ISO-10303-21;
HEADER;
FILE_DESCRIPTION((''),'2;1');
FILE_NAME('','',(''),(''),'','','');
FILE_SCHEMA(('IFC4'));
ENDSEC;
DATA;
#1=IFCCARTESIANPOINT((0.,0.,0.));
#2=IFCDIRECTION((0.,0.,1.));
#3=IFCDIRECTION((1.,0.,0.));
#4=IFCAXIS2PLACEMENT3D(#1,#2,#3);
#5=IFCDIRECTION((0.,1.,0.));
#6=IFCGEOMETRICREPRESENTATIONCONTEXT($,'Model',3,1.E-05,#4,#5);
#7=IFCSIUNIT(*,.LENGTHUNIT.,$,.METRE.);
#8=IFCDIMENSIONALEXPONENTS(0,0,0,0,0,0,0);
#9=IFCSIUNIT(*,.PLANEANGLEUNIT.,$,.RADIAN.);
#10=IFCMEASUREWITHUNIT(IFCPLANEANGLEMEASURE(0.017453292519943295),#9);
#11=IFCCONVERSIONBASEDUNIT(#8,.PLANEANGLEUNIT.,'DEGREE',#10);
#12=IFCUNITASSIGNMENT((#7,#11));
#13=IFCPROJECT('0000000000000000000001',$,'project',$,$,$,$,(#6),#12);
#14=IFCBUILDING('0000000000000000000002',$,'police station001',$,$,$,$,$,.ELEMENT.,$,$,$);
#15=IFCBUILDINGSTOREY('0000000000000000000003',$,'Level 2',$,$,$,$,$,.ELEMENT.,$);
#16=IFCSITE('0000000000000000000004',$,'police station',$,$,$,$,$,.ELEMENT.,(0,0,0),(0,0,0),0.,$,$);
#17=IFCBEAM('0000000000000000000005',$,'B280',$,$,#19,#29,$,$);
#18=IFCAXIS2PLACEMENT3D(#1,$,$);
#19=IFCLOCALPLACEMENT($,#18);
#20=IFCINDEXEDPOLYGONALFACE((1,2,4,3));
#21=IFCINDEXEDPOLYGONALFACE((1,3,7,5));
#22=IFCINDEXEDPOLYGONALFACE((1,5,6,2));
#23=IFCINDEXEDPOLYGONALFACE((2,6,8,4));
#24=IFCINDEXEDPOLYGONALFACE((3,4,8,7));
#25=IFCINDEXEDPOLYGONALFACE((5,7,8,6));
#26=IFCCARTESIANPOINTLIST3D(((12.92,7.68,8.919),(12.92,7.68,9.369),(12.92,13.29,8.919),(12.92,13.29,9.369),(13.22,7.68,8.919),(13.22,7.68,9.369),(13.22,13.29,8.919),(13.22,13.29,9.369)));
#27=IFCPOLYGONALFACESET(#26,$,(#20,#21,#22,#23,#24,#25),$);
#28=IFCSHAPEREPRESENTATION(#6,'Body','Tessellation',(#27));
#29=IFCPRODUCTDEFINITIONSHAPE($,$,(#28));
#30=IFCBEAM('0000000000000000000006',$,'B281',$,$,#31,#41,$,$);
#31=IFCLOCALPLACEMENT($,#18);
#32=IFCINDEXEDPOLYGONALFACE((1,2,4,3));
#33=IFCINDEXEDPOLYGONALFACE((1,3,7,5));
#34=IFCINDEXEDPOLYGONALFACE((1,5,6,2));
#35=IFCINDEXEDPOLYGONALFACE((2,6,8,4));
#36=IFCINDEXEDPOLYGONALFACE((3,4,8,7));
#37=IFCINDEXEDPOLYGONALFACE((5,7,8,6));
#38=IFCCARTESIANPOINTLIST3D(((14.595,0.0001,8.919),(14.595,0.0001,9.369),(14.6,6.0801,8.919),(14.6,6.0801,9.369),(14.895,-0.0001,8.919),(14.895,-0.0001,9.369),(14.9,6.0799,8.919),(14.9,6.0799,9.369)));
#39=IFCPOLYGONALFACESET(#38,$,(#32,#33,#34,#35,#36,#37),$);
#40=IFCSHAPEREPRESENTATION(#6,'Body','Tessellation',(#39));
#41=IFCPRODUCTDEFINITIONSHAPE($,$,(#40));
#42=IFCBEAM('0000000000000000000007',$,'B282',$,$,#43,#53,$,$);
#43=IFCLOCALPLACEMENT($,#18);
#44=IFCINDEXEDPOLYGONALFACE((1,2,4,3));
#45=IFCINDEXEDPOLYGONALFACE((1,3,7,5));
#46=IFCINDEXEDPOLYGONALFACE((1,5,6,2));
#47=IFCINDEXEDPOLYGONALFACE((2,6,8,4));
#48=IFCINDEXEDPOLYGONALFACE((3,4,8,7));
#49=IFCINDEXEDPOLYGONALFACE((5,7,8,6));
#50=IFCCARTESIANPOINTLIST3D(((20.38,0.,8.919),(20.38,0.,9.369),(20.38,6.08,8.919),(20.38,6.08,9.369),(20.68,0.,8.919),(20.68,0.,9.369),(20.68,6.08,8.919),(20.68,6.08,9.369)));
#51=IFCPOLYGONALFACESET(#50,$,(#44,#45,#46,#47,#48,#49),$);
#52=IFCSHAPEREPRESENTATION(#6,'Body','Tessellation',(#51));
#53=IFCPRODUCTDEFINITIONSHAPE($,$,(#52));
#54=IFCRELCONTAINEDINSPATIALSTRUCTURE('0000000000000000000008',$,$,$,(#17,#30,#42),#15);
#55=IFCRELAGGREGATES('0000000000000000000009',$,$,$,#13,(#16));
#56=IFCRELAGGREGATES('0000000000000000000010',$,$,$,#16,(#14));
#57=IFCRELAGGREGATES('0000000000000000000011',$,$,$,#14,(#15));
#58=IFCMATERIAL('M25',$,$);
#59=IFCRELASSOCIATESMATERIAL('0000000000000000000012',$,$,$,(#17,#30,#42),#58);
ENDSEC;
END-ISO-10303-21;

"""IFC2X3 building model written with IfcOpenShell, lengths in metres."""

from ifc_helpers import new_model, entity, si_unit, converted_unit, direction, frame, frame_2d, origin_with_axes, place, context, project, spatial, rectangle, extrude, material, element, save


model = new_model("IFC2X3")

# Units and contexts
model_context = context("Model", 3, precision=1e-05, world=origin_with_axes(), true_north=direction((0.0, 1.0, 0.0)))
ifc_project = project(units=[si_unit("LENGTHUNIT", "METRE"), converted_unit("PLANEANGLEUNIT", "DEGREE", entity("IfcPlaneAngleMeasure", 0.017453292519943295), si_unit("PLANEANGLEUNIT", "RADIAN"), dimensions=[0, 0, 0, 0, 0, 0, 0])], contexts=[model_context])

# Site, building, storey
site = spatial("IfcSite", under=ifc_project, Name="police station", CompositionType="ELEMENT", RefLatitude=(0, 0, 0), RefLongitude=(0, 0, 0), RefElevation=0.0)
building = spatial("IfcBuilding", under=site, Name="police station001", CompositionType="ELEMENT")
storey = spatial("IfcBuildingStorey", under=building, Name="Level 2", CompositionType="ELEMENT")

# Beams
ifc_material = material(Name="M25")
placement = place(None, origin_with_axes())
element("IfcBeam", 1, at=placement, inside=storey, material=ifc_material, Name="B280", context=model_context, shape_type="SweptSolid", body=[
    extrude(rectangle(XDim=0.3, YDim=0.45, at=frame_2d((0.0, 0.0), x_axis=(0.0, 1.0, 0.0))), frame((13.07, 13.29, 9.144), z_axis=(0.0, -1.0, 0.0), x_axis=(0.0, 0.0, -1.0)), (0.0, 0.0, 1.0), 5.61),
])
element("IfcBeam", 2, at=placement, inside=storey, material=ifc_material, Name="B281", context=model_context, shape_type="SweptSolid", body=[
    extrude(rectangle(XDim=0.3, YDim=0.45, at=frame_2d((0.0, 0.0), x_axis=(0.0, 1.0, 0.0))), frame((14.745, 0.0, 9.144), z_axis=(0.000822, 1.0, 0.0), x_axis=(0.0, 0.0, -1.0)), (0.0, 0.0, 1.0), 6.08),
])
element("IfcBeam", 3, at=placement, inside=storey, material=ifc_material, Name="B282", context=model_context, shape_type="SweptSolid", body=[
    extrude(rectangle(XDim=0.3, YDim=0.45, at=frame_2d((0.0, 0.0), x_axis=(0.0, 1.0, 0.0))), frame((20.53, 0.0, 9.144), z_axis=(0.0, 1.0, 0.0), x_axis=(0.0, 0.0, -1.0)), (0.0, 0.0, 1.0), 6.08),
])

save(model, "model.ifc")
